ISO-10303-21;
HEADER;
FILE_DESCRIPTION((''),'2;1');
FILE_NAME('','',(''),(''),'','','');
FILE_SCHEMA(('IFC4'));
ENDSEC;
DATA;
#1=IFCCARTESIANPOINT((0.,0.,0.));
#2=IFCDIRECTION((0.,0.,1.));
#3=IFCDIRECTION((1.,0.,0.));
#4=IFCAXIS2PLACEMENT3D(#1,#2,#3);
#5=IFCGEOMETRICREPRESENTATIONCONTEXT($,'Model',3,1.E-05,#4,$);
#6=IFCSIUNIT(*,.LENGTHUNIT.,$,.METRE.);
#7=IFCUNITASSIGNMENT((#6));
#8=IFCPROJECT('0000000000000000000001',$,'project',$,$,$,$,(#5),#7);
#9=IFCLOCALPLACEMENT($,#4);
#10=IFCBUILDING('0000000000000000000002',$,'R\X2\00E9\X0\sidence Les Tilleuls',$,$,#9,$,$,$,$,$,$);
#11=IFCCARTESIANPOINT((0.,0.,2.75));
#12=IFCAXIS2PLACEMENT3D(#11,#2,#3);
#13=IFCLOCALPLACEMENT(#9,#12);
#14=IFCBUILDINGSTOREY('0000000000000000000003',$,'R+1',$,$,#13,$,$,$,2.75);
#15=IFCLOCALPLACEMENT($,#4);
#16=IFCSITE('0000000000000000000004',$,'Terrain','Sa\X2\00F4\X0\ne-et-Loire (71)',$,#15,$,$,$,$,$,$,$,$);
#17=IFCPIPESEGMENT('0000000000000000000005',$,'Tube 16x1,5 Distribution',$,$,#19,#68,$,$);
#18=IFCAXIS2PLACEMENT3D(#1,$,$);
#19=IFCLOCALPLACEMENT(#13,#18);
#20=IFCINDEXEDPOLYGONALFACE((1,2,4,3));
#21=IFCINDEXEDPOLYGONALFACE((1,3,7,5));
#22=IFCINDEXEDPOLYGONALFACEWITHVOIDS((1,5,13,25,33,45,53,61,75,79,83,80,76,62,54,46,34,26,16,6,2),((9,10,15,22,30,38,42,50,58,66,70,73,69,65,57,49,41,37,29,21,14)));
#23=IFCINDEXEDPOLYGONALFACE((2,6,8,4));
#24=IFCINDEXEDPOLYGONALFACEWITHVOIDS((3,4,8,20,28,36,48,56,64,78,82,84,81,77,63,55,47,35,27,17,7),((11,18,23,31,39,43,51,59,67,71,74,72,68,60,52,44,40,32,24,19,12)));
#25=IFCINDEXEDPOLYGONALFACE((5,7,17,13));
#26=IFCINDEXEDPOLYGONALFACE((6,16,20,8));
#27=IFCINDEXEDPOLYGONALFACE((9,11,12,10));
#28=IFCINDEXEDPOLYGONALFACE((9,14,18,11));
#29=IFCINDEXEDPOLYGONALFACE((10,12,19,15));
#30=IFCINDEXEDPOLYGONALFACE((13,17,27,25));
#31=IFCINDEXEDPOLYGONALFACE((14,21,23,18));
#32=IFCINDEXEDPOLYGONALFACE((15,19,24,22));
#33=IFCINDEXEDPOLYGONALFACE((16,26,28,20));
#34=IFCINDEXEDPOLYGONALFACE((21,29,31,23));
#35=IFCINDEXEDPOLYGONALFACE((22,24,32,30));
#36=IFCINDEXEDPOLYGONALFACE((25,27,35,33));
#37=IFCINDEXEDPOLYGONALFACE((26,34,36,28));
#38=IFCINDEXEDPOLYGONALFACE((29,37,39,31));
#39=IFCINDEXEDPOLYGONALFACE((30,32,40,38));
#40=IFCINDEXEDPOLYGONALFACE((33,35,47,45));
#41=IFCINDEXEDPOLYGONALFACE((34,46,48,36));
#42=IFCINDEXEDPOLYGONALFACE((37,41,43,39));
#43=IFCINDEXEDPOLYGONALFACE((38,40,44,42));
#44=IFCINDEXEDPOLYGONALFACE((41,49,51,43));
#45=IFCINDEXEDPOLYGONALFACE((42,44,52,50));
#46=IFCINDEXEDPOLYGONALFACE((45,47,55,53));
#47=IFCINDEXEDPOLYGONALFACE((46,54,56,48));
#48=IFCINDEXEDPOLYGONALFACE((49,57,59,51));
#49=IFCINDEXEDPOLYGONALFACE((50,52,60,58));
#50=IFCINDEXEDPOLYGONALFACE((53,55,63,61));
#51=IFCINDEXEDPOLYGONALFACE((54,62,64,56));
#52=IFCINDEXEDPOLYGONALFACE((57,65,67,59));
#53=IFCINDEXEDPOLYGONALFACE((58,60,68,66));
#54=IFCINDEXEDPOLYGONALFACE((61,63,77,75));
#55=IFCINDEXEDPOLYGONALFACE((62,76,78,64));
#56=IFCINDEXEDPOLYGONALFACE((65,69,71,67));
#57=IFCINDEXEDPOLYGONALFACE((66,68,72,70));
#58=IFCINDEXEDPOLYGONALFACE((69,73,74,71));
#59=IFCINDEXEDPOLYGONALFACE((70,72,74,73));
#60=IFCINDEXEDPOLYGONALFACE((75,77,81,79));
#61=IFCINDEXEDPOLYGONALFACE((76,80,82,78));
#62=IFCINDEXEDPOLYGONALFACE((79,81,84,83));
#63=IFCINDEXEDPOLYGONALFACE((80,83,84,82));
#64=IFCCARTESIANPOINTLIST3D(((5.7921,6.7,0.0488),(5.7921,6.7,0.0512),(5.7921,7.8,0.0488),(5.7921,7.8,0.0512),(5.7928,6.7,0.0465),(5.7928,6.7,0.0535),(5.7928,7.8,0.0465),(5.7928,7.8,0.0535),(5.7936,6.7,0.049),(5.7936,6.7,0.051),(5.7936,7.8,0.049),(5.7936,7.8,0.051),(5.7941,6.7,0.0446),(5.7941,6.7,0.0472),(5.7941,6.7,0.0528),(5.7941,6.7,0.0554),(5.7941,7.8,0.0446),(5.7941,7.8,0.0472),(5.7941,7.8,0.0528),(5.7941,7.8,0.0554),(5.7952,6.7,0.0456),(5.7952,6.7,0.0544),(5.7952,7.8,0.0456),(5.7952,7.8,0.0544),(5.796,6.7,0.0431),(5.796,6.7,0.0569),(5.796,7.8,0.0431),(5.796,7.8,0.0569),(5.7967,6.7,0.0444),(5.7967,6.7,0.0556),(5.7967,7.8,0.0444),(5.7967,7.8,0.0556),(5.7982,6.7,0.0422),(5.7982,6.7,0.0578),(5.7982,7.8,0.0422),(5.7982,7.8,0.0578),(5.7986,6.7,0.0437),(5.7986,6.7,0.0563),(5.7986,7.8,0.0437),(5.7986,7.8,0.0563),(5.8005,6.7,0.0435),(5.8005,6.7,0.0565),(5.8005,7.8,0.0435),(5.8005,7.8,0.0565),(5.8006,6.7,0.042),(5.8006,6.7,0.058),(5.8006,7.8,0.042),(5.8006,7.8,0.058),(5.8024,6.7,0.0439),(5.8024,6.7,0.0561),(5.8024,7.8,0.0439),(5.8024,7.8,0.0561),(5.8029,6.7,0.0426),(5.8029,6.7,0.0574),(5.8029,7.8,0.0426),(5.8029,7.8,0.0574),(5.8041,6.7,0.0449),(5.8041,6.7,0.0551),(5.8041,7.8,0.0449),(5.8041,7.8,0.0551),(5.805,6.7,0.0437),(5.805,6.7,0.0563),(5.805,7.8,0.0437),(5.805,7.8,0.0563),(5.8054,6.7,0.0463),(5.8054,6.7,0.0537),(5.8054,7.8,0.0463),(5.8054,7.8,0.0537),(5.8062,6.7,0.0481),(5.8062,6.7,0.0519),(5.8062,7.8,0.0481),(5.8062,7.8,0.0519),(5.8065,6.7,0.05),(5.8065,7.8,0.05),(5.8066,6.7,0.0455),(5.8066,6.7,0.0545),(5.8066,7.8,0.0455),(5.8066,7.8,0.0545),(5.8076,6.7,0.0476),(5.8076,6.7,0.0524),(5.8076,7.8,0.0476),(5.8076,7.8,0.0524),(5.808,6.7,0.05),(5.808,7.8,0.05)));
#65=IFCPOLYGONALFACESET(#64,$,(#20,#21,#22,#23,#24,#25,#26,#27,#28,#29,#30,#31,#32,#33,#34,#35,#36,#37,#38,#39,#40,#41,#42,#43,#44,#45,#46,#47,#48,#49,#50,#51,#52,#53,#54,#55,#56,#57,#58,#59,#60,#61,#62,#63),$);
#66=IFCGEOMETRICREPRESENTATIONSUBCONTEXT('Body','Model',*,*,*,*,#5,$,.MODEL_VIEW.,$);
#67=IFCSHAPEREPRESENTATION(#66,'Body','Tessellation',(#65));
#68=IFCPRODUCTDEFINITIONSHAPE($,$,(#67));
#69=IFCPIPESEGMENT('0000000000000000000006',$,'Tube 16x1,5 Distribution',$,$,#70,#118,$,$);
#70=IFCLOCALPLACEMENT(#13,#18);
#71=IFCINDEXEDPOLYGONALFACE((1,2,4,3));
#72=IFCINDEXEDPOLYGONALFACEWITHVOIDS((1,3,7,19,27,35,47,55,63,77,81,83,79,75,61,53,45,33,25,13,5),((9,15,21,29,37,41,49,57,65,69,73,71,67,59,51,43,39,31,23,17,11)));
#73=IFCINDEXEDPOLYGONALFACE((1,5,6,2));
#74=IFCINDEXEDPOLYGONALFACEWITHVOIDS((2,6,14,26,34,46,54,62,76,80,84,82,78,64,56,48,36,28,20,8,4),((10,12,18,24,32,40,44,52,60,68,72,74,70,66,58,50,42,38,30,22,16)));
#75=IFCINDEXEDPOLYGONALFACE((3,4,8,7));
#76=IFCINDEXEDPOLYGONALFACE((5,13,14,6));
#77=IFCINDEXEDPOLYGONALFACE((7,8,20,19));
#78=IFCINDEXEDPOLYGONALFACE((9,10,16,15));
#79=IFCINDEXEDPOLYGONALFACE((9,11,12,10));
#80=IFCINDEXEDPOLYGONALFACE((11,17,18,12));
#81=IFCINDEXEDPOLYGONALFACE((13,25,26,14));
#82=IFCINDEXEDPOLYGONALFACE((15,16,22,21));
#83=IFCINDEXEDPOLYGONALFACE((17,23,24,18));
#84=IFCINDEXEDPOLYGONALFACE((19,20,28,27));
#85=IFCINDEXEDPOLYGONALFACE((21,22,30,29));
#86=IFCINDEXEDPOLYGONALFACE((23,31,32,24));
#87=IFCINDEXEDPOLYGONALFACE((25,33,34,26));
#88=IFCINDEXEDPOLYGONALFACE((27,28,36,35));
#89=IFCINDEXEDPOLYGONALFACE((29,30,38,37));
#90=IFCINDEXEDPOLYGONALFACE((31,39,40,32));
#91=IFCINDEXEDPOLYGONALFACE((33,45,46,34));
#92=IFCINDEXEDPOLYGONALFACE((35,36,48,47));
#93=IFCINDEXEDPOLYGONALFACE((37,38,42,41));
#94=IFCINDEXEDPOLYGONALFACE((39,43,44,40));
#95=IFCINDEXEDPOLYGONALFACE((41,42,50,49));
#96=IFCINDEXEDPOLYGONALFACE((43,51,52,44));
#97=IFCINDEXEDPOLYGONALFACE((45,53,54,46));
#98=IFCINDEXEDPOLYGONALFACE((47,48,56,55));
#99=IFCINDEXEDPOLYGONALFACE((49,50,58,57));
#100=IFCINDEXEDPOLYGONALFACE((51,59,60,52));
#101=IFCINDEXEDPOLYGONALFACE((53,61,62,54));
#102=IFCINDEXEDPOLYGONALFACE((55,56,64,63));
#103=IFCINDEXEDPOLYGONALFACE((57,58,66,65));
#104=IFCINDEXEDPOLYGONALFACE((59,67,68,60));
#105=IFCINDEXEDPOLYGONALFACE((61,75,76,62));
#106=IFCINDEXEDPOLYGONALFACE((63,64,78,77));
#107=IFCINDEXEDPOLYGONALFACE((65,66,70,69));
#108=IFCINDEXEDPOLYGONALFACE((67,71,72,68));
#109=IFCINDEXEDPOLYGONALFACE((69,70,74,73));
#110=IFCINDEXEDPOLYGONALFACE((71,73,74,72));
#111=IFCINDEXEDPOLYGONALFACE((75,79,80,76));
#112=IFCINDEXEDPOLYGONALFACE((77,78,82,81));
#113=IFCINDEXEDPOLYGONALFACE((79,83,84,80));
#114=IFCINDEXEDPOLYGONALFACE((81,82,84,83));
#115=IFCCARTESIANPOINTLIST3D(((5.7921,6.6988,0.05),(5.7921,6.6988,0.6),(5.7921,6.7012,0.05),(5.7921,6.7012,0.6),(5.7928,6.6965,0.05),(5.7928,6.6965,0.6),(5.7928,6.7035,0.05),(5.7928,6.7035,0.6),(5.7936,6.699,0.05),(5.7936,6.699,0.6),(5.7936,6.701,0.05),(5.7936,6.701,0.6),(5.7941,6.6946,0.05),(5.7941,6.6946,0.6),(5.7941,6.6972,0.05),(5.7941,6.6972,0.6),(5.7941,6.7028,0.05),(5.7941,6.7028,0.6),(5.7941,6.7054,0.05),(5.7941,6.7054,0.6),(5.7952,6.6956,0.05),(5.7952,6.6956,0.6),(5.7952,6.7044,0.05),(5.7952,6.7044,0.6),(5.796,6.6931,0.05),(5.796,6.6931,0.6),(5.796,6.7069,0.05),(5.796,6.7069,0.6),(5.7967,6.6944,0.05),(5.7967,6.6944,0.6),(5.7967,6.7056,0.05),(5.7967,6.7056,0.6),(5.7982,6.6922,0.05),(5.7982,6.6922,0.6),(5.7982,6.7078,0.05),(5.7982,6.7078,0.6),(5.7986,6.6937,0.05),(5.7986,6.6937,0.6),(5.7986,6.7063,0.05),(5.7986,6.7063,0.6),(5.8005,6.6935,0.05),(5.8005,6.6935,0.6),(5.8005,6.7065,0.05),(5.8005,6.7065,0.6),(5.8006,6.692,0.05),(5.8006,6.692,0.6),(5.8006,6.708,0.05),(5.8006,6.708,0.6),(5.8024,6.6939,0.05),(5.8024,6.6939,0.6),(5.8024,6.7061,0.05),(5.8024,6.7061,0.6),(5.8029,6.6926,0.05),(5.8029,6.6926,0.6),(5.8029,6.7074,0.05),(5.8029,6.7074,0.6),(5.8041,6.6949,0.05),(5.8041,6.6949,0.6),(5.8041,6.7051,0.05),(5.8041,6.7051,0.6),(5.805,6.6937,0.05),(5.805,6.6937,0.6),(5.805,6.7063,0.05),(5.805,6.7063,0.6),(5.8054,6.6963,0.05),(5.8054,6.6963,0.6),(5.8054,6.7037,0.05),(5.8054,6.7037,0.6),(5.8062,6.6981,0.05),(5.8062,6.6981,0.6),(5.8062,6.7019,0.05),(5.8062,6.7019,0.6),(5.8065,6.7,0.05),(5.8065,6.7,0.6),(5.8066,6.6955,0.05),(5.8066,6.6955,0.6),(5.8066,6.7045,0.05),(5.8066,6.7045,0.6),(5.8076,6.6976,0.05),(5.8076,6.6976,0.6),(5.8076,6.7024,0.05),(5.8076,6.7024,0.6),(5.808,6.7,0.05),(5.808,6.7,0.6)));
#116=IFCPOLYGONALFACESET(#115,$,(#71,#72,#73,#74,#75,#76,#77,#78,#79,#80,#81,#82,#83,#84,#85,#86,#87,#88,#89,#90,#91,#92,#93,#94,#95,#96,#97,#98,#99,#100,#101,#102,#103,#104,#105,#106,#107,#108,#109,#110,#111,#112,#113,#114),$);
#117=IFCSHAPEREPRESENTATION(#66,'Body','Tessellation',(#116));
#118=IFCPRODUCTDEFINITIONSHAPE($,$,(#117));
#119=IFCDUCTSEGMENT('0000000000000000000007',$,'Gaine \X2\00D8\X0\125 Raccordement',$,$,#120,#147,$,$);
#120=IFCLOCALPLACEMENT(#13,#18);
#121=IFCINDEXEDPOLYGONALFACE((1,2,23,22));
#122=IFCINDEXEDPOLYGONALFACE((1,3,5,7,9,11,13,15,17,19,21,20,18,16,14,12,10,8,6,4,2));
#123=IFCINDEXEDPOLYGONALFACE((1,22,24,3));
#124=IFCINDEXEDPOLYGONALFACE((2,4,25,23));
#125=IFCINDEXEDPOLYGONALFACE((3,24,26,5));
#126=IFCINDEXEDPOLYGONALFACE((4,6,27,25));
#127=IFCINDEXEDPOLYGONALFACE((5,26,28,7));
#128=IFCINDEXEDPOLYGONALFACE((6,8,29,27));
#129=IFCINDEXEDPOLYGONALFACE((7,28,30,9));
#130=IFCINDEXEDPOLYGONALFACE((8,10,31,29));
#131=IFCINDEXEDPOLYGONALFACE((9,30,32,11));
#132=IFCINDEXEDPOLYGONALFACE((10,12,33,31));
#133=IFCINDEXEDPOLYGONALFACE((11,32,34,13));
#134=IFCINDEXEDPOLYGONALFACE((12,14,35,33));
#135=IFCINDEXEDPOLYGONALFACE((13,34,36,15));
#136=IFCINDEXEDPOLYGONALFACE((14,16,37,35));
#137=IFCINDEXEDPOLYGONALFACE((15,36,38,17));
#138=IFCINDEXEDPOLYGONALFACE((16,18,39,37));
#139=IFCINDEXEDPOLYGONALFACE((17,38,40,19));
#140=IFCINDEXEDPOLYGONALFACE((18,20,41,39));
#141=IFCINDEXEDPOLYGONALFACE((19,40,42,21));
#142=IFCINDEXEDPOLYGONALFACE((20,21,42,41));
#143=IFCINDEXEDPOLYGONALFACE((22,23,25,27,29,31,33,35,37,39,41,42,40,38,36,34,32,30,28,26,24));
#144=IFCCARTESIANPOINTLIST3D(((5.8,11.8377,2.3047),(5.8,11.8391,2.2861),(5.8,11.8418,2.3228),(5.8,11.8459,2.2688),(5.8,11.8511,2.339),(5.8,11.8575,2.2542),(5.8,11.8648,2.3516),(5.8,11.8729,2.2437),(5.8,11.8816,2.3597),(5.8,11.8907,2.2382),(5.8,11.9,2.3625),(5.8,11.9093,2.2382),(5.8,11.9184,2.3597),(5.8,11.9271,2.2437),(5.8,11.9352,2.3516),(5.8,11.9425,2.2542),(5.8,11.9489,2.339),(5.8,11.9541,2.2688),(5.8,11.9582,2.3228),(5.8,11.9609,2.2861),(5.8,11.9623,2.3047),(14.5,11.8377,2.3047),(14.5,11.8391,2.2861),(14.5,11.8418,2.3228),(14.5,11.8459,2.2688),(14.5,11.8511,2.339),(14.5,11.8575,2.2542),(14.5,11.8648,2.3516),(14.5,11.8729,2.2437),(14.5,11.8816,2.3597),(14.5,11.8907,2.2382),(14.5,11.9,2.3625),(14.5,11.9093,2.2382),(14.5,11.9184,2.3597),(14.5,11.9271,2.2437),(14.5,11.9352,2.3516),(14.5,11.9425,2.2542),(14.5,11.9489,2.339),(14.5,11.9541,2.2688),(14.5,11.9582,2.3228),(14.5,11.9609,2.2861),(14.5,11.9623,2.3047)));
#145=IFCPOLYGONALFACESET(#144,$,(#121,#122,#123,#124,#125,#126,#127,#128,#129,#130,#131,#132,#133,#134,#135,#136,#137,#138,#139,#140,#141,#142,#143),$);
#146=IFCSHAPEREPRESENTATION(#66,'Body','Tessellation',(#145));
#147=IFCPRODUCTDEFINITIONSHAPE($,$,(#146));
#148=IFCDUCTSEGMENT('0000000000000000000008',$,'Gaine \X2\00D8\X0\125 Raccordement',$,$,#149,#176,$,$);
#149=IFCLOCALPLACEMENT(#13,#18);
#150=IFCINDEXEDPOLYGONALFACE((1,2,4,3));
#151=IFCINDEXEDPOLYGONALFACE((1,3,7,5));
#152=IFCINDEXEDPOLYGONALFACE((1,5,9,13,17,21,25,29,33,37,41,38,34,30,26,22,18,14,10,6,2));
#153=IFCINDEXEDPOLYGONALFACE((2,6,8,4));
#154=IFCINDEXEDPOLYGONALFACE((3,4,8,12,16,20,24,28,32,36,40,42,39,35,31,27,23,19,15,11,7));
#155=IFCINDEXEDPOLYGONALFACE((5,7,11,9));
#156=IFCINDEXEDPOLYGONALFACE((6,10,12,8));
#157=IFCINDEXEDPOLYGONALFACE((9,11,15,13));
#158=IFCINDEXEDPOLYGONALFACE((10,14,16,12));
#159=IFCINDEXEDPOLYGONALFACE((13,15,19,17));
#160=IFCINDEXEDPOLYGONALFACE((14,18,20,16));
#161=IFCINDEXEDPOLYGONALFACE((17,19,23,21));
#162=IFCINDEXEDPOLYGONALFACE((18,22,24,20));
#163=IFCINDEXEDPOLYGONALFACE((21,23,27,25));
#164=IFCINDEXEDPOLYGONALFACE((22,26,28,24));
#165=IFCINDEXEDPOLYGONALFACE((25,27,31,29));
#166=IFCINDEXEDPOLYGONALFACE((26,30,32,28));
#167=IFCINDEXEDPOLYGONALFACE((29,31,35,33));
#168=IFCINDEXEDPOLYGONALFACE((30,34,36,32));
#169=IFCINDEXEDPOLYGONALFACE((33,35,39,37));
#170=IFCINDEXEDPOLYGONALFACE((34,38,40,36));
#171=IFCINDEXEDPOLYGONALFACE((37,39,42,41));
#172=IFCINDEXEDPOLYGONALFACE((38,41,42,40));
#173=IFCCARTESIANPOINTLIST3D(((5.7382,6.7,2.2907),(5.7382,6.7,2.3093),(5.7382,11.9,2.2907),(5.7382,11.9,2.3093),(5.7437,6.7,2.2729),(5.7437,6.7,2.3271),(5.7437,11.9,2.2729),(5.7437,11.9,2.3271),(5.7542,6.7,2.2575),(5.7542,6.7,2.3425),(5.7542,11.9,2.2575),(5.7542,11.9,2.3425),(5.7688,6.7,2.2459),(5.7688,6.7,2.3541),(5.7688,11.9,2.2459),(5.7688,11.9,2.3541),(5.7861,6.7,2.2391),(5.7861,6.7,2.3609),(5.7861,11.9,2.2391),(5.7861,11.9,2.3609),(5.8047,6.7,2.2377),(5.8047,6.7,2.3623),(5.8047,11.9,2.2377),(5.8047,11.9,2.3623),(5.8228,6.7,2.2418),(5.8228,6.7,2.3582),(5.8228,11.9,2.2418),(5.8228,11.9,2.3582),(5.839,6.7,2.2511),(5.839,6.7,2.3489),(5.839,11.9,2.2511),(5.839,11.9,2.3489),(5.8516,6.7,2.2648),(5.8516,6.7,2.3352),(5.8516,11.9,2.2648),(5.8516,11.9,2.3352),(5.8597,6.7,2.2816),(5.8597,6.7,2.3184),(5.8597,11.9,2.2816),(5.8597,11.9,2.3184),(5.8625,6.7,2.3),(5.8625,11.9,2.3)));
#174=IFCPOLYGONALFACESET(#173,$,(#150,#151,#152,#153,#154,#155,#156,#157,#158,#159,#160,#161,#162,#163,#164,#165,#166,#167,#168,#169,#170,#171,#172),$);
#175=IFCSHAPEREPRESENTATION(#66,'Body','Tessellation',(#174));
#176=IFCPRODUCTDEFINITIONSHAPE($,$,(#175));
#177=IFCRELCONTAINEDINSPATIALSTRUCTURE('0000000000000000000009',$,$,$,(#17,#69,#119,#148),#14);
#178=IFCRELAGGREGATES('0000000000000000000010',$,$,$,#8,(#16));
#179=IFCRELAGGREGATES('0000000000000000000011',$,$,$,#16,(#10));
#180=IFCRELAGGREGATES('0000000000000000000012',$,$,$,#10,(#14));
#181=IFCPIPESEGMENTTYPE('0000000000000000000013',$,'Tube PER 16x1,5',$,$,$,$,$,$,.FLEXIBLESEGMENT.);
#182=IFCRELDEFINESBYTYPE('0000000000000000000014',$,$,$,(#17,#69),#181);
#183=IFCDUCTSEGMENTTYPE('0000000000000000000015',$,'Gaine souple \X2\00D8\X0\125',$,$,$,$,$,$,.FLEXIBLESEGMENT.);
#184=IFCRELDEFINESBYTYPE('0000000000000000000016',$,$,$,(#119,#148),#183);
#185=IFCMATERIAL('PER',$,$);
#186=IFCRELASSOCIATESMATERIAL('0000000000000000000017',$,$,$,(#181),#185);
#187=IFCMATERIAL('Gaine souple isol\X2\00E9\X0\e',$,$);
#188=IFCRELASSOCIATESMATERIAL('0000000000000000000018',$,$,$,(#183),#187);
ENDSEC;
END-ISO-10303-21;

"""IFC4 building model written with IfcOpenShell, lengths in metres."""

from ifc_helpers import new_model, si_unit, frame, origin_with_axes, place, context, subcontext, project, spatial, circle, hollow_circle, extrude, material, type_object, element, save


model = new_model("IFC4")

# Units and contexts
model_context = context("Model", 3, precision=1e-05, world=origin_with_axes())
body_context = subcontext(model_context, "Body", "Model", "MODEL_VIEW")
ifc_project = project(units=[si_unit("LENGTHUNIT", "METRE")], contexts=[model_context])

# Site, building, storey
site_placement = place(None, origin_with_axes())
site = spatial("IfcSite", under=ifc_project, at=site_placement, Name="Terrain", Description="Saône-et-Loire (71)")
building_placement = place(None, origin_with_axes())
building = spatial("IfcBuilding", under=site, at=building_placement, Name="Résidence Les Tilleuls")
storey_placement = place(building_placement, frame((0.0, 0.0, 2.75), z_axis=(0.0, 0.0, 1.0), x_axis=(1.0, 0.0, 0.0)))
storey = spatial("IfcBuildingStorey", under=building, at=storey_placement, Name="R+1", Elevation=2.75)

# Pipe segments
ifc_material_1 = material(Name="PER")
pipe_segment_type_1 = type_object("IfcPipeSegmentType", Name="Tube PER 16x1,5", PredefinedType="FLEXIBLESEGMENT", material=ifc_material_1)
pipe_segment_1_placement = place(storey_placement, frame((5.8, 7.8, 0.05), z_axis=(0.0, -1.0, 0.0), x_axis=(1.0, 0.0, 0.0)))
element("IfcPipeSegment", 1, at=pipe_segment_1_placement, inside=storey, type_object=pipe_segment_type_1, Name="Tube 16x1,5 Distribution", context=body_context, shape_type="SweptSolid", body=[
    extrude(hollow_circle(Radius=0.008, WallThickness=0.0015), origin_with_axes(), (0.0, 0.0, 1.0), 1.1),
])
pipe_segment_2_placement = place(storey_placement, frame((5.8, 6.7, 0.05), z_axis=(0.0, 0.0, 1.0), x_axis=(1.0, 0.0, 0.0)))
element("IfcPipeSegment", 2, at=pipe_segment_2_placement, inside=storey, type_object=pipe_segment_type_1, Name="Tube 16x1,5 Distribution", context=body_context, shape_type="SweptSolid", body=[
    extrude(hollow_circle(Radius=0.008, WallThickness=0.0015), origin_with_axes(), (0.0, 0.0, 1.0), 0.55),
])

# Duct segments
ifc_material_2 = material(Name="Gaine souple isolée")
duct_segment_type = type_object("IfcDuctSegmentType", Name="Gaine souple Ø125", PredefinedType="FLEXIBLESEGMENT", material=ifc_material_2)
duct_segment_1_placement = place(storey_placement, frame((5.8, 11.9, 2.3), z_axis=(1.0, 0.0, 0.0), x_axis=(0.0, 0.0, 1.0)))
element("IfcDuctSegment", 3, at=duct_segment_1_placement, inside=storey, type_object=duct_segment_type, Name="Gaine Ø125 Raccordement", context=body_context, shape_type="SweptSolid", body=[
    extrude(circle(Radius=0.0625), origin_with_axes(), (0.0, 0.0, 1.0), 8.7),
])
duct_segment_2_placement = place(storey_placement, frame((5.8, 6.7, 2.3), z_axis=(0.0, 1.0, 0.0), x_axis=(1.0, 0.0, 0.0)))
element("IfcDuctSegment", 4, at=duct_segment_2_placement, inside=storey, type_object=duct_segment_type, Name="Gaine Ø125 Raccordement", context=body_context, shape_type="SweptSolid", body=[
    extrude(circle(Radius=0.0625), origin_with_axes(), (0.0, 0.0, 1.0), 5.2),
])

save(model, "model.ifc")
